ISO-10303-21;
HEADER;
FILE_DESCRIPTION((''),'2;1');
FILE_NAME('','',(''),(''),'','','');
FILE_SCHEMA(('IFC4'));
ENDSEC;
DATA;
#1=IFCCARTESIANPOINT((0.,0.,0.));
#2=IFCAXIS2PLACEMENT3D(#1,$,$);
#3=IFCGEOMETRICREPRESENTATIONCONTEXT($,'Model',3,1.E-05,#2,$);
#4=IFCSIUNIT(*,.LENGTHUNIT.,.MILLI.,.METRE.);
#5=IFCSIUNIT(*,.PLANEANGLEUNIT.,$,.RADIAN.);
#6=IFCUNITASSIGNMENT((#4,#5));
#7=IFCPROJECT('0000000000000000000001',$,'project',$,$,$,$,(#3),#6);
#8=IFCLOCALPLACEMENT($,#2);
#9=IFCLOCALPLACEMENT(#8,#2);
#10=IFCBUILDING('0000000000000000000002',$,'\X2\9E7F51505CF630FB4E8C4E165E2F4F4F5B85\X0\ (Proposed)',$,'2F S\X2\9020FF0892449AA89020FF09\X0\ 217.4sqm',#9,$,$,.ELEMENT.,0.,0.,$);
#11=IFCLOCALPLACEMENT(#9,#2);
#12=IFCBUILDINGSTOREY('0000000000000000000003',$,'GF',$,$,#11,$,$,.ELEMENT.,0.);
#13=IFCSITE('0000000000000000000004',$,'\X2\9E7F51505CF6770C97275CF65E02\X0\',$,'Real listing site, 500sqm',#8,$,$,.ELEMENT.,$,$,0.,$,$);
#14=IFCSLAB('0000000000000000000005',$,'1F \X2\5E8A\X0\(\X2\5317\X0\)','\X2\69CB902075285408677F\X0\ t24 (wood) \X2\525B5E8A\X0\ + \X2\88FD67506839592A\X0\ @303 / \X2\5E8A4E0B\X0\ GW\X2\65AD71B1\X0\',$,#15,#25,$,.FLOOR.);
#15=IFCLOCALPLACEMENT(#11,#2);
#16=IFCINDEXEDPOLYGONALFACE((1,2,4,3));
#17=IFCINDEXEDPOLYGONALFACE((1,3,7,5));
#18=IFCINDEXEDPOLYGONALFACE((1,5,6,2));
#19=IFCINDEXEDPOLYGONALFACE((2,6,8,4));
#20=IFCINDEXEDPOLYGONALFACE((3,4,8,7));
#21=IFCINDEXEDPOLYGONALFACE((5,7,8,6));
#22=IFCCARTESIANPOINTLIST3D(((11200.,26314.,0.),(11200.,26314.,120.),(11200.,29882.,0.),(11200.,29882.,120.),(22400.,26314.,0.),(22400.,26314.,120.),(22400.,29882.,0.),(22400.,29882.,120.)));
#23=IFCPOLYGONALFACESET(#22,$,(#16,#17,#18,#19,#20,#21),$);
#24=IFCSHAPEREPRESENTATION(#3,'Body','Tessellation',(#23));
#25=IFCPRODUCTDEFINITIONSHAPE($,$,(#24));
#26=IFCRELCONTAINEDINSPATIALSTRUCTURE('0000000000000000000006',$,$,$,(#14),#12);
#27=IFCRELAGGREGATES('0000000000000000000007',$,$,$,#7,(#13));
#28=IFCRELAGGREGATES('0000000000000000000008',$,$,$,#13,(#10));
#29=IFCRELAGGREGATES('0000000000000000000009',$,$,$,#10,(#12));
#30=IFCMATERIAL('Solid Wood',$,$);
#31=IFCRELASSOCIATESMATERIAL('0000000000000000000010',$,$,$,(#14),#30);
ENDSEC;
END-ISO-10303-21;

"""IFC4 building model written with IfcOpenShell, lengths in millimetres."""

from ifc_helpers import new_model, si_unit, frame, frame_2d, origin, place, context, project, spatial, rectangle, extrude, material, element, save


model = new_model("IFC4")

# Units and contexts
model_context = context("Model", 3, precision=1e-05, world=origin())
ifc_project = project(units=[si_unit("LENGTHUNIT", "METRE", prefix="MILLI"), si_unit("PLANEANGLEUNIT", "RADIAN")], contexts=[model_context])

# Site, building, storey
site_placement = place(None, origin())
site = spatial("IfcSite", under=ifc_project, at=site_placement, Name="鹿児島県霧島市", ObjectType="Real listing site, 500sqm", CompositionType="ELEMENT", RefElevation=0.0)
building_placement = place(site_placement, origin())
building = spatial("IfcBuilding", under=site, at=building_placement, Name="鹿児島・二世帯住宅 (Proposed)", ObjectType="2F S造（鉄骨造） 217.4sqm", CompositionType="ELEMENT", ElevationOfRefHeight=0.0, ElevationOfTerrain=0.0)
storey_placement = place(building_placement, origin())
storey = spatial("IfcBuildingStorey", under=building, at=storey_placement, Name="GF", CompositionType="ELEMENT", Elevation=0.0)

# Shared definitions
ifc_material_1 = material(Name="Solid Wood")

# Slab
slab_1_placement = place(storey_placement, frame((5600.0, 13157.0, 0.0)))
element("IfcSlab", 1, at=slab_1_placement, inside=storey, material=ifc_material_1, Name="1F 床(北)", Description="構造用合板 t24 (wood) 剛床 + 製材根太 @303 / 床下 GW断熱", PredefinedType="FLOOR", context=model_context, shape_type="SweptSolid", body=[
    extrude(rectangle(XDim=11200.0, YDim=3568.0, at=frame_2d((5600.0, 1784.0))), frame((5600.0, 13157.0, 0.0)), (0.0, 0.0, 1.0), 120.0),
])

save(model, "model.ifc")
